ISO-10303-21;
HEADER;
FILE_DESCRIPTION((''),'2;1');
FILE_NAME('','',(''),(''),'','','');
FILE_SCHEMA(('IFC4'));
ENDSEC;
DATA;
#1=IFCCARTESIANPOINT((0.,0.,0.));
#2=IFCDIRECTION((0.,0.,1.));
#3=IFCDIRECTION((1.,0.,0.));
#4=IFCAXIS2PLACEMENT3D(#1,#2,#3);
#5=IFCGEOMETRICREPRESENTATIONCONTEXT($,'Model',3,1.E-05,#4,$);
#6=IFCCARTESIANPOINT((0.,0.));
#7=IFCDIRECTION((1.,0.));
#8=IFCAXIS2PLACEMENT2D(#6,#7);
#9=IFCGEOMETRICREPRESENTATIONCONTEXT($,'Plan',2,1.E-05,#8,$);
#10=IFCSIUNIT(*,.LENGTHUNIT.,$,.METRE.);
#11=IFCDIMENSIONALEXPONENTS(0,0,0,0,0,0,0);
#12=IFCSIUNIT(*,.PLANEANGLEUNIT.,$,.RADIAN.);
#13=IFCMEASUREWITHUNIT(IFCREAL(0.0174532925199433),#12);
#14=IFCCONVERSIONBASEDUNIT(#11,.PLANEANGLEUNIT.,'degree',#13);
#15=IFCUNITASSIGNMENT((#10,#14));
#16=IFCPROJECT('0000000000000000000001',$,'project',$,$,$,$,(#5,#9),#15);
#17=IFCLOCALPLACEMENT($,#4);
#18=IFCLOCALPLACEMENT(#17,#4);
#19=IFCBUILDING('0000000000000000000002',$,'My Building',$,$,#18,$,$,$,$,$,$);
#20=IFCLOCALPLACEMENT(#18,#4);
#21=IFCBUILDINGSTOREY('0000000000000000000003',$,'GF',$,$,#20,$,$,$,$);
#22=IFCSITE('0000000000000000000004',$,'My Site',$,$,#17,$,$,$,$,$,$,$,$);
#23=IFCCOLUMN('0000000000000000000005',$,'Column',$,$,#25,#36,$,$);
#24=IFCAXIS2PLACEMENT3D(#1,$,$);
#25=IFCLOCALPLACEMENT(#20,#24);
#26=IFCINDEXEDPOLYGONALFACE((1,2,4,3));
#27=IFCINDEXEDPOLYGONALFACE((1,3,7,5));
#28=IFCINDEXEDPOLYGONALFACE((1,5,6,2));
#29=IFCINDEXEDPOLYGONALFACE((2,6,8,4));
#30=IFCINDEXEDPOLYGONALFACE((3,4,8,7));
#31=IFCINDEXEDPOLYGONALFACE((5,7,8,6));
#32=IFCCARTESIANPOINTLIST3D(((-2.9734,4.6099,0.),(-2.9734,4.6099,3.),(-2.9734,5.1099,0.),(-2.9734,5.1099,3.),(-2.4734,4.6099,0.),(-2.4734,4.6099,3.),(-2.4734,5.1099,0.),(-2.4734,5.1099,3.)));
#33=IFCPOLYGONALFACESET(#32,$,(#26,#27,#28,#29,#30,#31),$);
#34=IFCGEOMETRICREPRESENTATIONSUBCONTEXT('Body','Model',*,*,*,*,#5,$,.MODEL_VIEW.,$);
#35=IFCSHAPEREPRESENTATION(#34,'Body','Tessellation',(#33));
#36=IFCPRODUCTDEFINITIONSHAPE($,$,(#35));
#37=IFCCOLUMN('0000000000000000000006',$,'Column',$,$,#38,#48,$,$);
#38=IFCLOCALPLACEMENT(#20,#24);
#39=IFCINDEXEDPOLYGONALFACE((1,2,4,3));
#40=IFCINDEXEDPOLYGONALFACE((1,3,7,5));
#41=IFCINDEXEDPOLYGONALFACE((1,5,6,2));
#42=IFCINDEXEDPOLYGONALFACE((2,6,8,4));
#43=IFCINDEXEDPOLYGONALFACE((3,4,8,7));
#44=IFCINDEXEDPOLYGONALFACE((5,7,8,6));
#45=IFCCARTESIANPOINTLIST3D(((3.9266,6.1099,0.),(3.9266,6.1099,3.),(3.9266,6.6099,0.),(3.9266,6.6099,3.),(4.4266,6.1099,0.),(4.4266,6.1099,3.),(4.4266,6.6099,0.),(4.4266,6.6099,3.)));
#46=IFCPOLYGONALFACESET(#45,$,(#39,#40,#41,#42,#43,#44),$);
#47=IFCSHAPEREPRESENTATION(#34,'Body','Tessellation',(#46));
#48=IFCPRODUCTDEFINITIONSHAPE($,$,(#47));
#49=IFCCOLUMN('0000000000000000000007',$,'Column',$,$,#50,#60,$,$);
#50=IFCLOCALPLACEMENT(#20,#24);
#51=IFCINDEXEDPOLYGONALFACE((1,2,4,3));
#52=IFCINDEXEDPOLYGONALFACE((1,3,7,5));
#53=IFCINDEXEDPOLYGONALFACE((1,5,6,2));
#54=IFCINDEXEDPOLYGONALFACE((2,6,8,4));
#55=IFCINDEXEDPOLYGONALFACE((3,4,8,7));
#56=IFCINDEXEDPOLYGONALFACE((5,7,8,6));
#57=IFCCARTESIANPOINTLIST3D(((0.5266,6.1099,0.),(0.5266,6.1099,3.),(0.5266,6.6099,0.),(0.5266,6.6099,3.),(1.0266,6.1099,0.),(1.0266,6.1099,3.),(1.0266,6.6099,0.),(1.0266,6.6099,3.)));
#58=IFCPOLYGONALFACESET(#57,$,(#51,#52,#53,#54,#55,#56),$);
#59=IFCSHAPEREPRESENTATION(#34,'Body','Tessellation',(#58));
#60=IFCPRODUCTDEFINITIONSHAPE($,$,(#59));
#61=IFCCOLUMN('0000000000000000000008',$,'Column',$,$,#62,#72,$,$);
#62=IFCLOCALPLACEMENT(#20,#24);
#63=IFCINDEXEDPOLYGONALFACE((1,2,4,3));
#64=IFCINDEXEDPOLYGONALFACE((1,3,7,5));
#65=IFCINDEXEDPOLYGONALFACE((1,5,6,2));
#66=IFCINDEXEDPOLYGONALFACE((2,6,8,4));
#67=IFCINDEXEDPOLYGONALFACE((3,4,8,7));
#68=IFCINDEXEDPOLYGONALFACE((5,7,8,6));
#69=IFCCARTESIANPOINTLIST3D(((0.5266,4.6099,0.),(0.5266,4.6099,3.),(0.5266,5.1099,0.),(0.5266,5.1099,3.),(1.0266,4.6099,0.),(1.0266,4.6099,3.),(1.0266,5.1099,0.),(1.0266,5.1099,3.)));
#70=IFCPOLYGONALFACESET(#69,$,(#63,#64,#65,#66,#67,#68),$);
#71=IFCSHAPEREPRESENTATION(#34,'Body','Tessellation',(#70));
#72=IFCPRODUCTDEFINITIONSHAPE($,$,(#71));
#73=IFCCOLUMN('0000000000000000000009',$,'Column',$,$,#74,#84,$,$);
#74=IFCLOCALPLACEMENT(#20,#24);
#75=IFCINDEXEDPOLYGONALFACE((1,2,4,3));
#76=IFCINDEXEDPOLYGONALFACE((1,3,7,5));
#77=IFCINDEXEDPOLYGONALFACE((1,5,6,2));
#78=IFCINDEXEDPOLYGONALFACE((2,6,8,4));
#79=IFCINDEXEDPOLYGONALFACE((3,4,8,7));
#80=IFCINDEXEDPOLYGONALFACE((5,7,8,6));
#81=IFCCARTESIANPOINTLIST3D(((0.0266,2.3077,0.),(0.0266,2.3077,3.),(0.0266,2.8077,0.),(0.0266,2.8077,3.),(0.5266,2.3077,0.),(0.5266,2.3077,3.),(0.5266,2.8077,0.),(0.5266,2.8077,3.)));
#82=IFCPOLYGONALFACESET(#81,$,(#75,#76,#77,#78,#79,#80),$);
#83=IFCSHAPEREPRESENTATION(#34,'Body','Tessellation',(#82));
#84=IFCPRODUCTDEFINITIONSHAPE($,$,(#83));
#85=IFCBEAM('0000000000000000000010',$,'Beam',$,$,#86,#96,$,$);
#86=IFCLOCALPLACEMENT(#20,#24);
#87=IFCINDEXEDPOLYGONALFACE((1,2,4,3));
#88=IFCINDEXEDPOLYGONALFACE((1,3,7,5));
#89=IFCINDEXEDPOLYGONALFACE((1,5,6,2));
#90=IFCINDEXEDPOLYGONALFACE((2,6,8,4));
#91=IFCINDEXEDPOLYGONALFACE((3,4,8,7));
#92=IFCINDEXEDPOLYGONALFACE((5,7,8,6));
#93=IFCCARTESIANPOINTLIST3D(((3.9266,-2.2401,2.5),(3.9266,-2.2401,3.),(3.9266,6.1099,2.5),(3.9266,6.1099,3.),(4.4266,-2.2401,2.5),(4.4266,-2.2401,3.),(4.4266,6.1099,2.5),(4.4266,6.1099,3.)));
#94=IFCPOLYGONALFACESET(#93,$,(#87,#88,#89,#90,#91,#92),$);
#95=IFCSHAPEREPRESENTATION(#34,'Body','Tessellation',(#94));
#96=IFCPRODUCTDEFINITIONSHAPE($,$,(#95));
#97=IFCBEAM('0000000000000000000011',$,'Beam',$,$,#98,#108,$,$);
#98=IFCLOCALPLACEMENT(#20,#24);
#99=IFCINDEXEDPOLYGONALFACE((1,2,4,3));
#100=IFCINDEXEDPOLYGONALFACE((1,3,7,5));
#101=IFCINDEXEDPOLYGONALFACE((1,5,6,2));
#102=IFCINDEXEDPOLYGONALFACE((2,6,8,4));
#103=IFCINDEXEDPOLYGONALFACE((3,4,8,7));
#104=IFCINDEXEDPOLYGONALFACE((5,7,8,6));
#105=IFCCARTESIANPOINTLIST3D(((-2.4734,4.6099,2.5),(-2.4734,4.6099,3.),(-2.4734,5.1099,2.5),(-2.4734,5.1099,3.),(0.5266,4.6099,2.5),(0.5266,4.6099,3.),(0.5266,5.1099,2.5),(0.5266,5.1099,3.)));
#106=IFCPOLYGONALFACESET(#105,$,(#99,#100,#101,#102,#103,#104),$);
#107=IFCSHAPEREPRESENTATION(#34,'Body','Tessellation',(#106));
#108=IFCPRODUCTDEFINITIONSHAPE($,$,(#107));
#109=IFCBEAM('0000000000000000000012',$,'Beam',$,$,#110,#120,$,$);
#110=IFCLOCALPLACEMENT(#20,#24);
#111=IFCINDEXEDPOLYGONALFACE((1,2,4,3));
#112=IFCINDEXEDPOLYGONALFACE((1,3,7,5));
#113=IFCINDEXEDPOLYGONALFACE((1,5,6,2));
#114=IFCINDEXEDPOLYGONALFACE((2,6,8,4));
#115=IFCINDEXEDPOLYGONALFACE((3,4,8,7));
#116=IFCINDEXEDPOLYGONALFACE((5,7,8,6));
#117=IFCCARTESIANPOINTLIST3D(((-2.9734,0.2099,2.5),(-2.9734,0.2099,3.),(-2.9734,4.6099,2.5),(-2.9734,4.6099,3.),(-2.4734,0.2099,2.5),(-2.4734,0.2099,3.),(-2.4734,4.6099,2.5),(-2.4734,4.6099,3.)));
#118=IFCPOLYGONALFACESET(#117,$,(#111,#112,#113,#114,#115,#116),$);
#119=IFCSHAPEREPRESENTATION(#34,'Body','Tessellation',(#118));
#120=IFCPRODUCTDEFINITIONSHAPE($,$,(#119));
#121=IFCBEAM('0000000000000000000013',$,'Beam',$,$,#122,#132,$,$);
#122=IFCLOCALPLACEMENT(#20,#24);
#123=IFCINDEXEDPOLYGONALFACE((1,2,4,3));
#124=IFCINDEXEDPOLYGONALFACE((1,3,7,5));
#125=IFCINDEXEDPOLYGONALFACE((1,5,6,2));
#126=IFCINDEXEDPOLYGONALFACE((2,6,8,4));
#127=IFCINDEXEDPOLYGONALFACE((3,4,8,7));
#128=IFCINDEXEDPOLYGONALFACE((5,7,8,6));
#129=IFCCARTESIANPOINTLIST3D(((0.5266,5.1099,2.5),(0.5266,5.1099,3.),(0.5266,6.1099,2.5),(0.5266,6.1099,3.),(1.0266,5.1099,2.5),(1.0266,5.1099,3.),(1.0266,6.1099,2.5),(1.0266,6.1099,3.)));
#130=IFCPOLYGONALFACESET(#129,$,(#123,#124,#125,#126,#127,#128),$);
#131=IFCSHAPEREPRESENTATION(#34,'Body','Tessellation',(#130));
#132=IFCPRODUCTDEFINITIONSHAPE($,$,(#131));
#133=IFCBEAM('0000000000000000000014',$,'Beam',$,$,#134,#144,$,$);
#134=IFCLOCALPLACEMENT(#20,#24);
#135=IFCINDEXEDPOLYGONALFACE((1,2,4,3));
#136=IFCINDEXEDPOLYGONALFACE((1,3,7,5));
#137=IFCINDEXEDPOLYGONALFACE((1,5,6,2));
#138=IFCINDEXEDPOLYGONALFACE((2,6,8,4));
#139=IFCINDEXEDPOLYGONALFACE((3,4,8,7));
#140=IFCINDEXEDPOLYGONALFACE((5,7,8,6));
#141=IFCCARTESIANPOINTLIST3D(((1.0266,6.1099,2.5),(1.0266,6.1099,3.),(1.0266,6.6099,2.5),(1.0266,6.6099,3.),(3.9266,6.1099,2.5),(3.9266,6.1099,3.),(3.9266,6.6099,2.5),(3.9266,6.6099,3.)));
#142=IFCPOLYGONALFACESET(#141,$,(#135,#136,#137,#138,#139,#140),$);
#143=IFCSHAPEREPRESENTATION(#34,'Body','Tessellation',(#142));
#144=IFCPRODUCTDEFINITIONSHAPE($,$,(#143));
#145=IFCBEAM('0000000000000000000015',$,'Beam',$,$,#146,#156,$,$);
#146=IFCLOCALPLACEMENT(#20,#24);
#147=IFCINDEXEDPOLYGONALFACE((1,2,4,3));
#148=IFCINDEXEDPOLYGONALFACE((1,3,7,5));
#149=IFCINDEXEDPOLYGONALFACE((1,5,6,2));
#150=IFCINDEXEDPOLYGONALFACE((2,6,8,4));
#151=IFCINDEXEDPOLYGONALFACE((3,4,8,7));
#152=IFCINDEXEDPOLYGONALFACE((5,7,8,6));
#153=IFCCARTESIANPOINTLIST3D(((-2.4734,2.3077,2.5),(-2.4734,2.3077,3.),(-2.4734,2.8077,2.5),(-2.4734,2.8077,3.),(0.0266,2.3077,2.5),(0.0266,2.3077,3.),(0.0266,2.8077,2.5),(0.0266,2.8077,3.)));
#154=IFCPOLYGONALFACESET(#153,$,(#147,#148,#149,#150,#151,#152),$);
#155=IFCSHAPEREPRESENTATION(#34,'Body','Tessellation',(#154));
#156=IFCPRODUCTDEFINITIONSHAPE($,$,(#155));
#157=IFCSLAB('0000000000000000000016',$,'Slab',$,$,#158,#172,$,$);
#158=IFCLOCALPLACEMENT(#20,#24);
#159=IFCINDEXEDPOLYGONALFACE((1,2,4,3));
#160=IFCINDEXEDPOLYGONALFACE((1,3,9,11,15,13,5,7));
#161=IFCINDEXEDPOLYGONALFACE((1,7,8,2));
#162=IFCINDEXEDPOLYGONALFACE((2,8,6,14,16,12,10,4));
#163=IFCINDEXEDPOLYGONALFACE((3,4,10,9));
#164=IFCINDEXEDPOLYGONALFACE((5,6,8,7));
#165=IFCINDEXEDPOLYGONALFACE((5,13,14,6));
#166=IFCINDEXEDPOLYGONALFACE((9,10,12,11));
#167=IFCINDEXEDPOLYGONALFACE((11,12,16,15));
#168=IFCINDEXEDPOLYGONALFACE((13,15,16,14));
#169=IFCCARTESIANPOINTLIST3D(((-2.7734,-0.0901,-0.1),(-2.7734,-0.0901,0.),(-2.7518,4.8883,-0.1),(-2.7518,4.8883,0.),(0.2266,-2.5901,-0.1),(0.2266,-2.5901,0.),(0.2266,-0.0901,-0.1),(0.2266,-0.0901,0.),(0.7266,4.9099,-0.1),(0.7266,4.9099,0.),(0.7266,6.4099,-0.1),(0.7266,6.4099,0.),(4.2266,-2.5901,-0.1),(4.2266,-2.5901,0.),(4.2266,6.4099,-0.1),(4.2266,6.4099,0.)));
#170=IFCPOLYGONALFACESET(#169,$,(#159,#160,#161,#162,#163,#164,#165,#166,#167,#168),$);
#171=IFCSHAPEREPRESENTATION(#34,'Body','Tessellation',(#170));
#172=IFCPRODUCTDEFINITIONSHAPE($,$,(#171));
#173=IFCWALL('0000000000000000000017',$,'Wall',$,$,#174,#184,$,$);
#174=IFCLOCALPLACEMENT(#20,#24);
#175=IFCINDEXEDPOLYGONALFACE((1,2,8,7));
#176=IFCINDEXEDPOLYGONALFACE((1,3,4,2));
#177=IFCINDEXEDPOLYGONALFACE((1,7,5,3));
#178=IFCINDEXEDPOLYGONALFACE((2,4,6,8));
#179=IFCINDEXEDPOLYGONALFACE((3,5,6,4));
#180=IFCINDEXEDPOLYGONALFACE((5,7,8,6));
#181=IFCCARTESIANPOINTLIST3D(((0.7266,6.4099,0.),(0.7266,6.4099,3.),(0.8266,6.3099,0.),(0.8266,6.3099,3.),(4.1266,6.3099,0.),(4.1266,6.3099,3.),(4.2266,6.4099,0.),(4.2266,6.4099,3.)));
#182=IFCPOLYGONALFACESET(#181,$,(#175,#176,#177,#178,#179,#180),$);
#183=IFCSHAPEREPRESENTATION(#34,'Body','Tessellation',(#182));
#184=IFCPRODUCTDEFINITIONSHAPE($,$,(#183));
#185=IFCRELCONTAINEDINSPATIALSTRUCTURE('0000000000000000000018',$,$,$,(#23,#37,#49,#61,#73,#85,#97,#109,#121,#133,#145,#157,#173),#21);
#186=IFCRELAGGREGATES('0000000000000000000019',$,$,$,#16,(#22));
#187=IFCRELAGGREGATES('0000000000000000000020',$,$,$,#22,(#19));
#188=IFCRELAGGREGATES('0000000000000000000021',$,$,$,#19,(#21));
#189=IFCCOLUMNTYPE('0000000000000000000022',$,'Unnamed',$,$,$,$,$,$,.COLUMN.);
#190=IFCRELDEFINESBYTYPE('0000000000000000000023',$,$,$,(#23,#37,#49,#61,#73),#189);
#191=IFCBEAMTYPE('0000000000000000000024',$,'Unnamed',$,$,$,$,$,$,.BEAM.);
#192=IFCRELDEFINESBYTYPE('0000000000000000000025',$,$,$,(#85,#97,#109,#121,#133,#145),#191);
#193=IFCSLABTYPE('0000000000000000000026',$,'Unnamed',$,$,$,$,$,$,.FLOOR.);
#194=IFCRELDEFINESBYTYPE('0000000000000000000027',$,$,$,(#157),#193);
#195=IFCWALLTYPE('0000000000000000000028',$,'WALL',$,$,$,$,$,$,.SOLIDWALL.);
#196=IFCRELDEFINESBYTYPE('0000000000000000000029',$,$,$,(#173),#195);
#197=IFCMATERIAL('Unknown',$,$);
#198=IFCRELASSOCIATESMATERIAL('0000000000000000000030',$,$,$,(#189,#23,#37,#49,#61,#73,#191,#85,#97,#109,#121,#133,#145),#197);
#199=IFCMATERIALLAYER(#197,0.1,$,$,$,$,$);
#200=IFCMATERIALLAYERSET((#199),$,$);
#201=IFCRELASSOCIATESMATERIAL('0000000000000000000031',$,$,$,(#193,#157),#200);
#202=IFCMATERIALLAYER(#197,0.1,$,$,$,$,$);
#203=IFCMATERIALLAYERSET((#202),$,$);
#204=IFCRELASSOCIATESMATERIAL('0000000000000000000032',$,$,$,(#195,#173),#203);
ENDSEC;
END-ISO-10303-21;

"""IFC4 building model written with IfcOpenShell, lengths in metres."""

from ifc_helpers import new_model, entity, si_unit, converted_unit, frame, origin_with_axes, origin_2d_with_axis, place, context, subcontext, project, spatial, line, indexed_curve, rectangle, outline, extrude, material, layer, layer_set, layer_usage, material_profile, profile_set, profile_usage, type_object, element, save


model = new_model("IFC4")

# Units and contexts
model_context = context("Model", 3, precision=1e-05, world=origin_with_axes())
plan_context = context("Plan", 2, precision=1e-05, world=origin_2d_with_axis())
body_context_1 = subcontext(model_context, "Body", "Model", "MODEL_VIEW")
ifc_project = project(units=[si_unit("LENGTHUNIT", "METRE"), converted_unit("PLANEANGLEUNIT", "degree", entity("IfcReal", 0.0174532925199433), si_unit("PLANEANGLEUNIT", "RADIAN"), dimensions=[0, 0, 0, 0, 0, 0, 0])], contexts=[model_context, plan_context])

# Site, building, storey
site_placement = place(None, origin_with_axes())
site = spatial("IfcSite", under=ifc_project, at=site_placement, Name="My Site")
building_placement = place(site_placement, origin_with_axes())
building = spatial("IfcBuilding", under=site, at=building_placement, Name="My Building")
storey_placement = place(building_placement, origin_with_axes())
storey = spatial("IfcBuildingStorey", under=building, at=storey_placement, Name="GF")

# Columns
ifc_material = material(Name="Unknown")
ifc_material_profile_1 = material_profile(ifc_material, rectangle(XDim=0.5, YDim=0.5))
ifc_profile_set_1 = profile_set([ifc_material_profile_1])
ifc_profile_usage_1 = profile_usage(ifc_profile_set_1, cardinal=5)
column_type = type_object("IfcColumnType", Name="Unnamed", PredefinedType="COLUMN", material=ifc_profile_set_1)
column_1_placement = place(storey_placement, frame((-2.7234, 4.8599, 0.0), z_axis=(0.0, 0.0, 1.0), x_axis=(1.0, 0.0, 0.0)))
element("IfcColumn", 1, at=column_1_placement, inside=storey, type_object=column_type, material=ifc_profile_usage_1, Name="Column", context=body_context_1, shape_type="SweptSolid", body=[
    extrude(rectangle(XDim=0.5, YDim=0.5), origin_with_axes(), (0.0, 0.0, 1.0), 3.0),
])
ifc_profile_usage_2 = profile_usage(ifc_profile_set_1, cardinal=5)
column_2_placement = place(storey_placement, frame((4.1766, 6.3599, 0.0), z_axis=(0.0, 0.0, 1.0), x_axis=(1.0, 0.0, 0.0)))
element("IfcColumn", 2, at=column_2_placement, inside=storey, type_object=column_type, material=ifc_profile_usage_2, Name="Column", context=body_context_1, shape_type="SweptSolid", body=[
    extrude(rectangle(XDim=0.5, YDim=0.5), origin_with_axes(), (0.0, 0.0, 1.0), 3.0),
])
ifc_profile_usage_3 = profile_usage(ifc_profile_set_1, cardinal=5)
column_3_placement = place(storey_placement, frame((0.7766, 6.3599, 0.0), z_axis=(0.0, 0.0, 1.0), x_axis=(1.0, 0.0, 0.0)))
element("IfcColumn", 3, at=column_3_placement, inside=storey, type_object=column_type, material=ifc_profile_usage_3, Name="Column", context=body_context_1, shape_type="SweptSolid", body=[
    extrude(rectangle(XDim=0.5, YDim=0.5), origin_with_axes(), (0.0, 0.0, 1.0), 3.0),
])
ifc_profile_usage_4 = profile_usage(ifc_profile_set_1, cardinal=5)
column_4_placement = place(storey_placement, frame((0.7766, 4.8599, 0.0), z_axis=(0.0, 0.0, 1.0), x_axis=(1.0, 0.0, 0.0)))
element("IfcColumn", 4, at=column_4_placement, inside=storey, type_object=column_type, material=ifc_profile_usage_4, Name="Column", context=body_context_1, shape_type="SweptSolid", body=[
    extrude(rectangle(XDim=0.5, YDim=0.5), origin_with_axes(), (0.0, 0.0, 1.0), 3.0),
])
ifc_profile_usage_5 = profile_usage(ifc_profile_set_1, cardinal=5)
column_5_placement = place(storey_placement, frame((0.2766, 2.5577, 0.0), z_axis=(0.0, 0.0, 1.0), x_axis=(1.0, 0.0, 0.0)))
element("IfcColumn", 5, at=column_5_placement, inside=storey, type_object=column_type, material=ifc_profile_usage_5, Name="Column", context=body_context_1, shape_type="SweptSolid", body=[
    extrude(rectangle(XDim=0.5, YDim=0.5), origin_with_axes(), (0.0, 0.0, 1.0), 3.0),
])

# Beams
ifc_material_profile_2 = material_profile(ifc_material, rectangle(XDim=0.5, YDim=0.5))
ifc_profile_set_2 = profile_set([ifc_material_profile_2])
ifc_profile_usage_6 = profile_usage(ifc_profile_set_2, cardinal=7)
beam_type = type_object("IfcBeamType", Name="Unnamed", PredefinedType="BEAM", material=ifc_profile_set_2)
beam_1_placement = place(storey_placement, frame((4.4266, 6.1099, 3.0), z_axis=(0.0, -1.0, 0.0), x_axis=(1.0, 0.0, 0.0)))
element("IfcBeam", 6, at=beam_1_placement, inside=storey, type_object=beam_type, material=ifc_profile_usage_6, Name="Beam", context=body_context_1, shape_type="SweptSolid", body=[
    extrude(rectangle(XDim=0.5, YDim=0.5), frame((-0.25, -0.25, 0.0), z_axis=(0.0, 0.0, 1.0), x_axis=(1.0, 0.0, 0.0)), (0.0, 0.0, 1.0), 8.35),
])
ifc_profile_usage_7 = profile_usage(ifc_profile_set_2, cardinal=7)
beam_2_placement = place(storey_placement, frame((-2.4734, 5.1099, 3.0), z_axis=(1.0, 0.0, 0.0), x_axis=(0.0, 1.0, 0.0)))
element("IfcBeam", 7, at=beam_2_placement, inside=storey, type_object=beam_type, material=ifc_profile_usage_7, Name="Beam", context=body_context_1, shape_type="SweptSolid", body=[
    extrude(rectangle(XDim=0.5, YDim=0.5), frame((-0.25, -0.25, 0.0), z_axis=(0.0, 0.0, 1.0), x_axis=(1.0, 0.0, 0.0)), (0.0, 0.0, 1.0), 3.0),
])
ifc_profile_usage_8 = profile_usage(ifc_profile_set_2, cardinal=7)
beam_3_placement = place(storey_placement, frame((-2.4734, 4.6099, 3.0), z_axis=(0.0, -1.0, 0.0), x_axis=(1.0, 0.0, 0.0)))
element("IfcBeam", 8, at=beam_3_placement, inside=storey, type_object=beam_type, material=ifc_profile_usage_8, Name="Beam", context=body_context_1, shape_type="SweptSolid", body=[
    extrude(rectangle(XDim=0.5, YDim=0.5), frame((-0.25, -0.25, 0.0), z_axis=(0.0, 0.0, 1.0), x_axis=(1.0, 0.0, 0.0)), (0.0, 0.0, 1.0), 4.4),
])
ifc_profile_usage_9 = profile_usage(ifc_profile_set_2, cardinal=7)
beam_4_placement = place(storey_placement, frame((1.0266, 6.1099, 3.0), z_axis=(0.0, -1.0, 0.0), x_axis=(1.0, 0.0, 0.0)))
element("IfcBeam", 9, at=beam_4_placement, inside=storey, type_object=beam_type, material=ifc_profile_usage_9, Name="Beam", context=body_context_1, shape_type="SweptSolid", body=[
    extrude(rectangle(XDim=0.5, YDim=0.5), frame((-0.25, -0.25, 0.0), z_axis=(0.0, 0.0, 1.0), x_axis=(1.0, 0.0, 0.0)), (0.0, 0.0, 1.0), 1.0),
])
ifc_profile_usage_10 = profile_usage(ifc_profile_set_2, cardinal=7)
beam_5_placement = place(storey_placement, frame((1.0266, 6.6099, 3.0), z_axis=(1.0, -0.000001, 0.0), x_axis=(0.000001, 1.0, 0.0)))
element("IfcBeam", 10, at=beam_5_placement, inside=storey, type_object=beam_type, material=ifc_profile_usage_10, Name="Beam", context=body_context_1, shape_type="SweptSolid", body=[
    extrude(rectangle(XDim=0.5, YDim=0.5), frame((-0.25, -0.25, 0.0), z_axis=(0.0, 0.0, 1.0), x_axis=(1.0, 0.0, 0.0)), (0.0, 0.0, 1.0), 2.9),
])
ifc_profile_usage_11 = profile_usage(ifc_profile_set_2, cardinal=7)
beam_6_placement = place(storey_placement, frame((-2.4734, 2.8077, 3.0), z_axis=(1.0, 0.0, 0.0), x_axis=(0.0, 1.0, 0.0)))
element("IfcBeam", 11, at=beam_6_placement, inside=storey, type_object=beam_type, material=ifc_profile_usage_11, Name="Beam", context=body_context_1, shape_type="SweptSolid", body=[
    extrude(rectangle(XDim=0.5, YDim=0.5), frame((-0.25, -0.25, 0.0), z_axis=(0.0, 0.0, 1.0), x_axis=(1.0, 0.0, 0.0)), (0.0, 0.0, 1.0), 2.5),
])

# Slab
ifc_layer_1 = layer(ifc_material, 0.1)
ifc_layer_set_1 = layer_set([ifc_layer_1])
ifc_layer_usage_1 = layer_usage(ifc_layer_set_1, "AXIS3", "POSITIVE", -0.1)
slab_type = type_object("IfcSlabType", Name="Unnamed", PredefinedType="FLOOR", material=ifc_layer_set_1)
slab_placement = place(storey_placement, frame((0.7266, 6.4099, 0.0), z_axis=(0.0, 0.0, 1.0), x_axis=(1.0, 0.0, 0.0)))
element("IfcSlab", 12, at=slab_placement, inside=storey, type_object=slab_type, material=ifc_layer_usage_1, Name="Slab", context=body_context_1, shape_type="SweptSolid", body=[
    extrude(outline(indexed_curve([(0.0, 0.0), (3.5, 0.0), (3.5, -9.0), (-0.5, -9.0), (-0.5, -6.5), (-3.5, -6.5), (-3.4784, -1.5216), (0.0, -1.5), (0.0, 0.0)])), frame((0.0, 0.0, -0.1), z_axis=(0.0, 0.0, 1.0), x_axis=(1.0, 0.0, 0.0)), (0.0, 0.0, 1.0), 0.1),
])

# Wall
ifc_layer_2 = layer(ifc_material, 0.1)
ifc_layer_set_2 = layer_set([ifc_layer_2])
ifc_layer_usage_2 = layer_usage(ifc_layer_set_2, "AXIS2", "POSITIVE", 0.0)
wall_type = type_object("IfcWallType", Name="WALL", PredefinedType="SOLIDWALL", material=ifc_layer_set_2)
wall_1_placement = place(storey_placement, frame((4.2266, 6.4099, 0.0), z_axis=(0.0, 0.0, 1.0), x_axis=(-1.0, 0.0, 0.0)))
element("IfcWall", 13, at=wall_1_placement, inside=storey, type_object=wall_type, material=ifc_layer_usage_2, Name="Wall", context=body_context_1, shape_type="SweptSolid", body=[
    extrude(outline(indexed_curve([(0.0, 0.0), (0.1, 0.1), (3.4, 0.1), (3.5, 0.0)], segments=[line(1, 2, 3, 4, 1)])), origin_with_axes(), (0.0, 0.0, 1.0), 3.0),
])

save(model, "model.ifc")
